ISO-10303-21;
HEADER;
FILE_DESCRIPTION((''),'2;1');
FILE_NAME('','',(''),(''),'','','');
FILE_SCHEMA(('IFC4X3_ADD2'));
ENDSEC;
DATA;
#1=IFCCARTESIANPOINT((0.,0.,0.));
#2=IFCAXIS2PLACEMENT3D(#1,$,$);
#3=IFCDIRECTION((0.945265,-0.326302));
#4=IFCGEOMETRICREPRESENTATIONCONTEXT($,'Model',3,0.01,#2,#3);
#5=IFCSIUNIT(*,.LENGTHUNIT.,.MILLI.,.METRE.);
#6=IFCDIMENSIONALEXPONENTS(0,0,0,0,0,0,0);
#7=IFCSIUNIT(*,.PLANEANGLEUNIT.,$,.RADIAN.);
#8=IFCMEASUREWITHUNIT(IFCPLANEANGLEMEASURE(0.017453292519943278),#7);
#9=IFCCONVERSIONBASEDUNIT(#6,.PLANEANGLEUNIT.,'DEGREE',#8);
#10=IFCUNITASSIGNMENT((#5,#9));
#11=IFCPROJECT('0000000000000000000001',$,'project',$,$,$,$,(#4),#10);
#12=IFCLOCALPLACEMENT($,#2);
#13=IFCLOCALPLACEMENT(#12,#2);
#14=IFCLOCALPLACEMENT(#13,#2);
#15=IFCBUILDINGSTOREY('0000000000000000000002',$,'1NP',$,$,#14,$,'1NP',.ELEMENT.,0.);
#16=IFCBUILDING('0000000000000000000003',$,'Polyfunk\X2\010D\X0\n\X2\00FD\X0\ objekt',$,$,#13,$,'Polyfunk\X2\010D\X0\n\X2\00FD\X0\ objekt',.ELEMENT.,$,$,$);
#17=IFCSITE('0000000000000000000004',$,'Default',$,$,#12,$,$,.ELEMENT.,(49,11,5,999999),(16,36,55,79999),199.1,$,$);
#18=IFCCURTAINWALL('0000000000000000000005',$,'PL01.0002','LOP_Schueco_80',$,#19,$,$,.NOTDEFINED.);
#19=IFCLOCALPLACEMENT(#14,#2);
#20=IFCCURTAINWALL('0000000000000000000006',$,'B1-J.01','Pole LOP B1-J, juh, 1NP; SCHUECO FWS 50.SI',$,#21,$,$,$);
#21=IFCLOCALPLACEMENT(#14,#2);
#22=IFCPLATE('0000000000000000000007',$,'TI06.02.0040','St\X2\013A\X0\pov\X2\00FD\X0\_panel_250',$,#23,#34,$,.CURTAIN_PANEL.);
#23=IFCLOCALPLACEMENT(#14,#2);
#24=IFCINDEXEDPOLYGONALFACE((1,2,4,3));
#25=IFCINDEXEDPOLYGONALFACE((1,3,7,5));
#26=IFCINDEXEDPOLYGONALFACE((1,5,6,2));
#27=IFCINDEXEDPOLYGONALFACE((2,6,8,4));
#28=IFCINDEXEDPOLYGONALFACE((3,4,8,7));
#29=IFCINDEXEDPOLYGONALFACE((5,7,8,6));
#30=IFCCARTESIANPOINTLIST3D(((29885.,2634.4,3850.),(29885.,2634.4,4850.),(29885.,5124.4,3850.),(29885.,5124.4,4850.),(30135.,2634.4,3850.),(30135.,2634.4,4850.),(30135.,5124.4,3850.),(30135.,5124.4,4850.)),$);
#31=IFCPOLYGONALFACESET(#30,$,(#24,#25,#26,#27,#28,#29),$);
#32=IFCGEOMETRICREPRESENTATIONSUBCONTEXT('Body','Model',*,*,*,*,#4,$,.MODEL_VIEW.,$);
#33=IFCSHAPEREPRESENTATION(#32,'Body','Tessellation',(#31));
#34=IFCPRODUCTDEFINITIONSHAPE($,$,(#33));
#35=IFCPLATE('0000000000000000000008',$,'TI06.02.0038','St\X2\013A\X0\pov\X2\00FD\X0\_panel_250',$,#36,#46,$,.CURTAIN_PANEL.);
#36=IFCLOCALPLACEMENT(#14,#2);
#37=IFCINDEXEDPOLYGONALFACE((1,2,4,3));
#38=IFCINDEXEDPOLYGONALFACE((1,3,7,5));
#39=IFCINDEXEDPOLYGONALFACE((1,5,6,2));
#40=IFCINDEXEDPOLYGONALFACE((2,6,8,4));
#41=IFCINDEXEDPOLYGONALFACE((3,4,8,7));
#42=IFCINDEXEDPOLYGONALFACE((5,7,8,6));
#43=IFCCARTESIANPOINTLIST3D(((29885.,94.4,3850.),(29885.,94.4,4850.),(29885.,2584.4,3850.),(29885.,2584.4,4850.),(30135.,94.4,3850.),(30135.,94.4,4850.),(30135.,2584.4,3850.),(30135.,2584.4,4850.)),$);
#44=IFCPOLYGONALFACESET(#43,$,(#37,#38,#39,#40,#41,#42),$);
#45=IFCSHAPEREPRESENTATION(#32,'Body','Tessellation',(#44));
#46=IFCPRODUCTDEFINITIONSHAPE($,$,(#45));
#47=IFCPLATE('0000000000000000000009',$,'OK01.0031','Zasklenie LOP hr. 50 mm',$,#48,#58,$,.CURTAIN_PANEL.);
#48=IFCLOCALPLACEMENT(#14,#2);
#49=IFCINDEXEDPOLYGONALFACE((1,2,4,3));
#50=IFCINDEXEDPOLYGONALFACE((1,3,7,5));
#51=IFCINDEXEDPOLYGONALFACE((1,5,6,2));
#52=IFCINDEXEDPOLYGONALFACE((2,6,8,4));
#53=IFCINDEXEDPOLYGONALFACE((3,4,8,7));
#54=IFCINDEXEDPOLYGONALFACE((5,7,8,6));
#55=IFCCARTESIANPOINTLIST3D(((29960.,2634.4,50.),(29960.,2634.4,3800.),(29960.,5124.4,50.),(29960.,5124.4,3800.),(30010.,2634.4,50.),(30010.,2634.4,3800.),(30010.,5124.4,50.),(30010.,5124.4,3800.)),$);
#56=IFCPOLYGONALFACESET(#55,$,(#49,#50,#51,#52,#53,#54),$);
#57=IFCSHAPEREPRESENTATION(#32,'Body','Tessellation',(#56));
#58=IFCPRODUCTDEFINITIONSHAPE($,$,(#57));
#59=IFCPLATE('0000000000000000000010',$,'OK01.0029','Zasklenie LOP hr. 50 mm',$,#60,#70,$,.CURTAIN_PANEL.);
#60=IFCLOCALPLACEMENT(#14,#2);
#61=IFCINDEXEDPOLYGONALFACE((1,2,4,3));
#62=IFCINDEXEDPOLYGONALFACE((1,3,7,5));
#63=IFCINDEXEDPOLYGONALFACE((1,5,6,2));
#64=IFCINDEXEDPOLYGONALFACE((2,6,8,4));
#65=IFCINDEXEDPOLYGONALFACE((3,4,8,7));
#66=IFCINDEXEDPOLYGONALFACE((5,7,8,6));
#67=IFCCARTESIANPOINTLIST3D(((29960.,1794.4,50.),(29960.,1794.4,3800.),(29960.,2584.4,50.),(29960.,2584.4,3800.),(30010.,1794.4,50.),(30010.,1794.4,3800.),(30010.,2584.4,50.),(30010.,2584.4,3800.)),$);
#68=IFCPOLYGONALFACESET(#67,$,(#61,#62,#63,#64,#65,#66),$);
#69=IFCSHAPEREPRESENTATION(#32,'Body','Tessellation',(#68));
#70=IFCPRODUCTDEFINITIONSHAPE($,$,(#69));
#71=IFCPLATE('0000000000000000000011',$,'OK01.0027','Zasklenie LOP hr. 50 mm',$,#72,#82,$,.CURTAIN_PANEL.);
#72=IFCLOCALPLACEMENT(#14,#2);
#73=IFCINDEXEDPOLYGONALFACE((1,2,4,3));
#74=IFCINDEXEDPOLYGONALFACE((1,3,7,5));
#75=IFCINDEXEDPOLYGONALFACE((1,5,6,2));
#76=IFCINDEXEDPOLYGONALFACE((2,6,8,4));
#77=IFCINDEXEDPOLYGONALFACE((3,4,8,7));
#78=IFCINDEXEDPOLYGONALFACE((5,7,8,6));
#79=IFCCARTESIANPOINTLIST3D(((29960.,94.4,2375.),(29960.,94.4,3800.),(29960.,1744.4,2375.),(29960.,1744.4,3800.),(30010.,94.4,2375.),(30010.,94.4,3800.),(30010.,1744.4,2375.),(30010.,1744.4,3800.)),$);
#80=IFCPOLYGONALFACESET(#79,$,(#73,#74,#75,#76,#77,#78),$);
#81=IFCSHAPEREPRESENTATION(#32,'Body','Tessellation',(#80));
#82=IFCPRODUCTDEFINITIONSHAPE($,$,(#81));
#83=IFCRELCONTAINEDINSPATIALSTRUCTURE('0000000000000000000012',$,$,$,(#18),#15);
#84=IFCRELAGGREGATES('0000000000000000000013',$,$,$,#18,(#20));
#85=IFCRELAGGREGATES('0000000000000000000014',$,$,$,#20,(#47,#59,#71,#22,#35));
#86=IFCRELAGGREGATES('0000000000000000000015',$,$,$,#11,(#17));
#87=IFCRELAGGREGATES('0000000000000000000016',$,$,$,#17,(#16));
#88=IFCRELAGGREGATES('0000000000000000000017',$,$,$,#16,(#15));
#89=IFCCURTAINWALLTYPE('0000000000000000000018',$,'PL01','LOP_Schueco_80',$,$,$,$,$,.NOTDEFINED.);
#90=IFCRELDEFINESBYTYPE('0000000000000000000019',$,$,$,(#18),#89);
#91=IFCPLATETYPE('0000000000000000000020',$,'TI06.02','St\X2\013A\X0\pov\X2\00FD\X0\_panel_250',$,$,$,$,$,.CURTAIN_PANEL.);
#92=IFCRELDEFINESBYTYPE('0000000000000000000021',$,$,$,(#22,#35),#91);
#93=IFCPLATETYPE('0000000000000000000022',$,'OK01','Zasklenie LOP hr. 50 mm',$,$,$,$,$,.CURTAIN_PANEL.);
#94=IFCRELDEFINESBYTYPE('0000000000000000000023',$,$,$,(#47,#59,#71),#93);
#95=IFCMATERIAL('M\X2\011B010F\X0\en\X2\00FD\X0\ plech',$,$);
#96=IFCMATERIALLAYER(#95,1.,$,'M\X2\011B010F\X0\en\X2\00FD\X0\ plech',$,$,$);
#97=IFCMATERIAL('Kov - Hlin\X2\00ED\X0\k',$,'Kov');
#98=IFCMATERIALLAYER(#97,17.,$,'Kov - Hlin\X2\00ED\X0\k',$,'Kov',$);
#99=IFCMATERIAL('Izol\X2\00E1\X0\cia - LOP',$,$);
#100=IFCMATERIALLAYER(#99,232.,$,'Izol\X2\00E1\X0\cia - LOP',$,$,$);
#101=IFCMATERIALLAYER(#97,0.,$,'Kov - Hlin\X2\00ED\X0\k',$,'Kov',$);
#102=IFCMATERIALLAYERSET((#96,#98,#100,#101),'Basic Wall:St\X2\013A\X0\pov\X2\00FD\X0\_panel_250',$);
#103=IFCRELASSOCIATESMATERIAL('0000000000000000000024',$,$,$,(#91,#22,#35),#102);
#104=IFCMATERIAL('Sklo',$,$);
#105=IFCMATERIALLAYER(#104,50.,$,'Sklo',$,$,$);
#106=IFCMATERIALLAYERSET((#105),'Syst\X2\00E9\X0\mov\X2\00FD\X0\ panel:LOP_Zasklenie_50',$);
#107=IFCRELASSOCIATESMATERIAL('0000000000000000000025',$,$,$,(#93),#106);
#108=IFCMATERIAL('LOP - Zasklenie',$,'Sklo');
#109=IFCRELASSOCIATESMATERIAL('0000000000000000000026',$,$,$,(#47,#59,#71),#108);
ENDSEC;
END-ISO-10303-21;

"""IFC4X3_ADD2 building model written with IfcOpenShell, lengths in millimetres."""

from ifc_helpers import new_model, entity, si_unit, converted_unit, direction, frame, frame_2d, origin, origin_2d_with_axis, place, context, subcontext, project, spatial, rectangle, extrude, source, transform, mapped, material, layer, layer_set, layer_usage, type_object, type_shapes, element, aggregate, save


model = new_model("IFC4X3_ADD2")

# Units and contexts
model_context = context("Model", 3, precision=0.01, world=origin(), true_north=direction((0.945265, -0.326302)))
body_context = subcontext(model_context, "Body", "Model", "MODEL_VIEW")
ifc_project = project(units=[si_unit("LENGTHUNIT", "METRE", prefix="MILLI"), converted_unit("PLANEANGLEUNIT", "DEGREE", entity("IfcPlaneAngleMeasure", 0.017453292519943278), si_unit("PLANEANGLEUNIT", "RADIAN"), dimensions=[0, 0, 0, 0, 0, 0, 0])], contexts=[model_context])

# Site, building, storey
site_placement = place(None, origin())
site = spatial("IfcSite", under=ifc_project, at=site_placement, Name="Default", CompositionType="ELEMENT", RefLatitude=(49, 11, 5, 999999), RefLongitude=(16, 36, 55, 79999), RefElevation=199.1)
building_placement = place(site_placement, origin())
building = spatial("IfcBuilding", under=site, at=building_placement, Name="Polyfunkčný objekt", LongName="Polyfunkčný objekt", CompositionType="ELEMENT")
storey_placement = place(building_placement, origin())
storey = spatial("IfcBuildingStorey", under=building, at=storey_placement, Name="1NP", LongName="1NP", CompositionType="ELEMENT", Elevation=0.0)

# Curtain walls, plates
curtain_wall_type = type_object("IfcCurtainWallType", Name="PL01", Description="LOP_Schueco_80", PredefinedType="NOTDEFINED")
curtain_wall_1_placement = place(storey_placement, origin())
curtain_wall_1 = element("IfcCurtainWall", 1, at=curtain_wall_1_placement, inside=storey, type_object=curtain_wall_type, Name="PL01.0002", Description="LOP_Schueco_80", PredefinedType="NOTDEFINED")
curtain_wall_2 = element("IfcCurtainWall", 2, Name="B1-J.01", Description="Pole LOP B1-J, juh, 1NP; SCHUECO FWS 50.SI")
aggregate(curtain_wall_1, [curtain_wall_2])
ifc_material_1 = material(Name="Měďený plech")
ifc_layer_1 = layer(ifc_material_1, 1.0, Name="Měďený plech")
ifc_material_2 = material(Name="Kov - Hliník", Category="Kov")
ifc_layer_2 = layer(ifc_material_2, 17.0, Name="Kov - Hliník", Category="Kov")
ifc_material_3 = material(Name="Izolácia - LOP")
ifc_layer_3 = layer(ifc_material_3, 232.0, Name="Izolácia - LOP")
ifc_layer_4 = layer(ifc_material_2, 0.0, Name="Kov - Hliník", Category="Kov")
ifc_layer_set_1 = layer_set([ifc_layer_1, ifc_layer_2, ifc_layer_3, ifc_layer_4], Name="Basic Wall:Stĺpový_panel_250")
ifc_layer_usage_1 = layer_usage(ifc_layer_set_1, "AXIS2", "POSITIVE", -125.0)
plate_type_1 = type_object("IfcPlateType", Name="TI06.02", Description="Stĺpový_panel_250", PredefinedType="CURTAIN_PANEL", material=ifc_layer_set_1)
plate_1_placement = place(storey_placement, frame((30010.0, 5124.4, 3850.0), z_axis=(0.0, 0.0, 1.0), x_axis=(0.0, -1.0, 0.0)))
plate_1 = element("IfcPlate", 3, at=plate_1_placement, type_object=plate_type_1, material=ifc_layer_usage_1, Name="TI06.02.0040", Description="Stĺpový_panel_250", PredefinedType="CURTAIN_PANEL", context=body_context, shape_type="SweptSolid", body=[
    extrude(rectangle(XDim=250.0, YDim=2490.0, at=frame_2d((0.0, 0.0), x_axis=(1.0, 0.0))), frame((1245.0, 0.0, 0.0), z_axis=(0.0, 0.0, 1.0), x_axis=(0.0, 1.0, 0.0)), (0.0, 0.0, 1.0), 1000.0),
])
ifc_layer_usage_2 = layer_usage(ifc_layer_set_1, "AXIS2", "POSITIVE", -125.0)
plate_2_placement = place(storey_placement, frame((30010.0, 2584.4, 3850.0), z_axis=(0.0, 0.0, 1.0), x_axis=(0.0, -1.0, 0.0)))
plate_2 = element("IfcPlate", 4, at=plate_2_placement, type_object=plate_type_1, material=ifc_layer_usage_2, Name="TI06.02.0038", Description="Stĺpový_panel_250", PredefinedType="CURTAIN_PANEL", context=body_context, shape_type="SweptSolid", body=[
    extrude(rectangle(XDim=250.0, YDim=2490.0, at=frame_2d((0.0, 0.0), x_axis=(1.0, 0.0))), frame((1245.0, 0.0, 0.0), z_axis=(0.0, 0.0, 1.0), x_axis=(0.0, 1.0, 0.0)), (0.0, 0.0, 1.0), 1000.0),
])
ifc_material_4 = material(Name="LOP - Zasklenie", Category="Sklo")
ifc_material_5 = material(Name="Sklo")
ifc_layer_5 = layer(ifc_material_5, 50.0, Name="Sklo")
ifc_layer_set_2 = layer_set([ifc_layer_5], Name="Systémový panel:LOP_Zasklenie_50")
plate_type_2 = type_object("IfcPlateType", Name="OK01", Description="Zasklenie LOP hr. 50 mm", PredefinedType="CURTAIN_PANEL", material=ifc_layer_set_2)
shared_shape_1 = source(origin(), body_context, "Body", "SweptSolid", [
    extrude(rectangle(XDim=3750.0, YDim=2490.0, at=frame_2d((-141.7, 0.0), x_axis=(1.0, 0.0))), frame((0.0, -50.0, 2016.7), z_axis=(0.0, 1.0, 0.0), x_axis=(0.0, 0.0, 1.0)), (0.0, 0.0, 1.0), 50.0),
])
plate_3_placement = place(curtain_wall_1_placement, frame((30010.0, 3879.4, 50.0), z_axis=(0.0, 0.0, 1.0), x_axis=(0.0, -1.0, 0.0)))
plate_3 = element("IfcPlate", 5, at=plate_3_placement, type_object=plate_type_2, material=ifc_material_4, Name="OK01.0031", Description="Zasklenie LOP hr. 50 mm", PredefinedType="CURTAIN_PANEL", context=body_context, shape_type="MappedRepresentation", body=[
    mapped(shared_shape_1, transform((0.0, 0.0, 0.0), scale=1.0)),
])
shared_shape_2 = source(origin(), body_context, "Body", "SweptSolid", [
    extrude(rectangle(XDim=3750.0, YDim=790.0, at=frame_2d((-141.7, 0.0), x_axis=(1.0, 0.0))), frame((0.0, -50.0, 2016.7), z_axis=(0.0, 1.0, 0.0), x_axis=(0.0, 0.0, 1.0)), (0.0, 0.0, 1.0), 50.0),
])
plate_4_placement = place(curtain_wall_1_placement, frame((30010.0, 2189.4, 50.0), z_axis=(0.0, 0.0, 1.0), x_axis=(0.0, -1.0, 0.0)))
plate_4 = element("IfcPlate", 6, at=plate_4_placement, type_object=plate_type_2, material=ifc_material_4, Name="OK01.0029", Description="Zasklenie LOP hr. 50 mm", PredefinedType="CURTAIN_PANEL", context=body_context, shape_type="MappedRepresentation", body=[
    mapped(shared_shape_2, transform((0.0, 0.0, 0.0), scale=1.0)),
])
shared_shape_3 = source(origin(), body_context, "Body", "SweptSolid", [
    extrude(rectangle(XDim=50.0, YDim=1650.0, at=origin_2d_with_axis()), frame((0.0, -25.0, 0.0), z_axis=(0.0, 0.0, 1.0), x_axis=(0.0, 1.0, 0.0)), (0.0, 0.0, 1.0), 1425.0),
])
type_shapes(plate_type_2, [shared_shape_1, shared_shape_2, shared_shape_3])
plate_5_placement = place(curtain_wall_1_placement, frame((30010.0, 919.4, 2375.0), z_axis=(0.0, 0.0, 1.0), x_axis=(0.0, -1.0, 0.0)))
plate_5 = element("IfcPlate", 7, at=plate_5_placement, type_object=plate_type_2, material=ifc_material_4, Name="OK01.0027", Description="Zasklenie LOP hr. 50 mm", PredefinedType="CURTAIN_PANEL", context=body_context, shape_type="MappedRepresentation", body=[
    mapped(shared_shape_3, transform((0.0, 0.0, 0.0), scale=1.0)),
])
aggregate(curtain_wall_2, [plate_3, plate_4, plate_5, plate_1, plate_2])

save(model, "model.ifc")
